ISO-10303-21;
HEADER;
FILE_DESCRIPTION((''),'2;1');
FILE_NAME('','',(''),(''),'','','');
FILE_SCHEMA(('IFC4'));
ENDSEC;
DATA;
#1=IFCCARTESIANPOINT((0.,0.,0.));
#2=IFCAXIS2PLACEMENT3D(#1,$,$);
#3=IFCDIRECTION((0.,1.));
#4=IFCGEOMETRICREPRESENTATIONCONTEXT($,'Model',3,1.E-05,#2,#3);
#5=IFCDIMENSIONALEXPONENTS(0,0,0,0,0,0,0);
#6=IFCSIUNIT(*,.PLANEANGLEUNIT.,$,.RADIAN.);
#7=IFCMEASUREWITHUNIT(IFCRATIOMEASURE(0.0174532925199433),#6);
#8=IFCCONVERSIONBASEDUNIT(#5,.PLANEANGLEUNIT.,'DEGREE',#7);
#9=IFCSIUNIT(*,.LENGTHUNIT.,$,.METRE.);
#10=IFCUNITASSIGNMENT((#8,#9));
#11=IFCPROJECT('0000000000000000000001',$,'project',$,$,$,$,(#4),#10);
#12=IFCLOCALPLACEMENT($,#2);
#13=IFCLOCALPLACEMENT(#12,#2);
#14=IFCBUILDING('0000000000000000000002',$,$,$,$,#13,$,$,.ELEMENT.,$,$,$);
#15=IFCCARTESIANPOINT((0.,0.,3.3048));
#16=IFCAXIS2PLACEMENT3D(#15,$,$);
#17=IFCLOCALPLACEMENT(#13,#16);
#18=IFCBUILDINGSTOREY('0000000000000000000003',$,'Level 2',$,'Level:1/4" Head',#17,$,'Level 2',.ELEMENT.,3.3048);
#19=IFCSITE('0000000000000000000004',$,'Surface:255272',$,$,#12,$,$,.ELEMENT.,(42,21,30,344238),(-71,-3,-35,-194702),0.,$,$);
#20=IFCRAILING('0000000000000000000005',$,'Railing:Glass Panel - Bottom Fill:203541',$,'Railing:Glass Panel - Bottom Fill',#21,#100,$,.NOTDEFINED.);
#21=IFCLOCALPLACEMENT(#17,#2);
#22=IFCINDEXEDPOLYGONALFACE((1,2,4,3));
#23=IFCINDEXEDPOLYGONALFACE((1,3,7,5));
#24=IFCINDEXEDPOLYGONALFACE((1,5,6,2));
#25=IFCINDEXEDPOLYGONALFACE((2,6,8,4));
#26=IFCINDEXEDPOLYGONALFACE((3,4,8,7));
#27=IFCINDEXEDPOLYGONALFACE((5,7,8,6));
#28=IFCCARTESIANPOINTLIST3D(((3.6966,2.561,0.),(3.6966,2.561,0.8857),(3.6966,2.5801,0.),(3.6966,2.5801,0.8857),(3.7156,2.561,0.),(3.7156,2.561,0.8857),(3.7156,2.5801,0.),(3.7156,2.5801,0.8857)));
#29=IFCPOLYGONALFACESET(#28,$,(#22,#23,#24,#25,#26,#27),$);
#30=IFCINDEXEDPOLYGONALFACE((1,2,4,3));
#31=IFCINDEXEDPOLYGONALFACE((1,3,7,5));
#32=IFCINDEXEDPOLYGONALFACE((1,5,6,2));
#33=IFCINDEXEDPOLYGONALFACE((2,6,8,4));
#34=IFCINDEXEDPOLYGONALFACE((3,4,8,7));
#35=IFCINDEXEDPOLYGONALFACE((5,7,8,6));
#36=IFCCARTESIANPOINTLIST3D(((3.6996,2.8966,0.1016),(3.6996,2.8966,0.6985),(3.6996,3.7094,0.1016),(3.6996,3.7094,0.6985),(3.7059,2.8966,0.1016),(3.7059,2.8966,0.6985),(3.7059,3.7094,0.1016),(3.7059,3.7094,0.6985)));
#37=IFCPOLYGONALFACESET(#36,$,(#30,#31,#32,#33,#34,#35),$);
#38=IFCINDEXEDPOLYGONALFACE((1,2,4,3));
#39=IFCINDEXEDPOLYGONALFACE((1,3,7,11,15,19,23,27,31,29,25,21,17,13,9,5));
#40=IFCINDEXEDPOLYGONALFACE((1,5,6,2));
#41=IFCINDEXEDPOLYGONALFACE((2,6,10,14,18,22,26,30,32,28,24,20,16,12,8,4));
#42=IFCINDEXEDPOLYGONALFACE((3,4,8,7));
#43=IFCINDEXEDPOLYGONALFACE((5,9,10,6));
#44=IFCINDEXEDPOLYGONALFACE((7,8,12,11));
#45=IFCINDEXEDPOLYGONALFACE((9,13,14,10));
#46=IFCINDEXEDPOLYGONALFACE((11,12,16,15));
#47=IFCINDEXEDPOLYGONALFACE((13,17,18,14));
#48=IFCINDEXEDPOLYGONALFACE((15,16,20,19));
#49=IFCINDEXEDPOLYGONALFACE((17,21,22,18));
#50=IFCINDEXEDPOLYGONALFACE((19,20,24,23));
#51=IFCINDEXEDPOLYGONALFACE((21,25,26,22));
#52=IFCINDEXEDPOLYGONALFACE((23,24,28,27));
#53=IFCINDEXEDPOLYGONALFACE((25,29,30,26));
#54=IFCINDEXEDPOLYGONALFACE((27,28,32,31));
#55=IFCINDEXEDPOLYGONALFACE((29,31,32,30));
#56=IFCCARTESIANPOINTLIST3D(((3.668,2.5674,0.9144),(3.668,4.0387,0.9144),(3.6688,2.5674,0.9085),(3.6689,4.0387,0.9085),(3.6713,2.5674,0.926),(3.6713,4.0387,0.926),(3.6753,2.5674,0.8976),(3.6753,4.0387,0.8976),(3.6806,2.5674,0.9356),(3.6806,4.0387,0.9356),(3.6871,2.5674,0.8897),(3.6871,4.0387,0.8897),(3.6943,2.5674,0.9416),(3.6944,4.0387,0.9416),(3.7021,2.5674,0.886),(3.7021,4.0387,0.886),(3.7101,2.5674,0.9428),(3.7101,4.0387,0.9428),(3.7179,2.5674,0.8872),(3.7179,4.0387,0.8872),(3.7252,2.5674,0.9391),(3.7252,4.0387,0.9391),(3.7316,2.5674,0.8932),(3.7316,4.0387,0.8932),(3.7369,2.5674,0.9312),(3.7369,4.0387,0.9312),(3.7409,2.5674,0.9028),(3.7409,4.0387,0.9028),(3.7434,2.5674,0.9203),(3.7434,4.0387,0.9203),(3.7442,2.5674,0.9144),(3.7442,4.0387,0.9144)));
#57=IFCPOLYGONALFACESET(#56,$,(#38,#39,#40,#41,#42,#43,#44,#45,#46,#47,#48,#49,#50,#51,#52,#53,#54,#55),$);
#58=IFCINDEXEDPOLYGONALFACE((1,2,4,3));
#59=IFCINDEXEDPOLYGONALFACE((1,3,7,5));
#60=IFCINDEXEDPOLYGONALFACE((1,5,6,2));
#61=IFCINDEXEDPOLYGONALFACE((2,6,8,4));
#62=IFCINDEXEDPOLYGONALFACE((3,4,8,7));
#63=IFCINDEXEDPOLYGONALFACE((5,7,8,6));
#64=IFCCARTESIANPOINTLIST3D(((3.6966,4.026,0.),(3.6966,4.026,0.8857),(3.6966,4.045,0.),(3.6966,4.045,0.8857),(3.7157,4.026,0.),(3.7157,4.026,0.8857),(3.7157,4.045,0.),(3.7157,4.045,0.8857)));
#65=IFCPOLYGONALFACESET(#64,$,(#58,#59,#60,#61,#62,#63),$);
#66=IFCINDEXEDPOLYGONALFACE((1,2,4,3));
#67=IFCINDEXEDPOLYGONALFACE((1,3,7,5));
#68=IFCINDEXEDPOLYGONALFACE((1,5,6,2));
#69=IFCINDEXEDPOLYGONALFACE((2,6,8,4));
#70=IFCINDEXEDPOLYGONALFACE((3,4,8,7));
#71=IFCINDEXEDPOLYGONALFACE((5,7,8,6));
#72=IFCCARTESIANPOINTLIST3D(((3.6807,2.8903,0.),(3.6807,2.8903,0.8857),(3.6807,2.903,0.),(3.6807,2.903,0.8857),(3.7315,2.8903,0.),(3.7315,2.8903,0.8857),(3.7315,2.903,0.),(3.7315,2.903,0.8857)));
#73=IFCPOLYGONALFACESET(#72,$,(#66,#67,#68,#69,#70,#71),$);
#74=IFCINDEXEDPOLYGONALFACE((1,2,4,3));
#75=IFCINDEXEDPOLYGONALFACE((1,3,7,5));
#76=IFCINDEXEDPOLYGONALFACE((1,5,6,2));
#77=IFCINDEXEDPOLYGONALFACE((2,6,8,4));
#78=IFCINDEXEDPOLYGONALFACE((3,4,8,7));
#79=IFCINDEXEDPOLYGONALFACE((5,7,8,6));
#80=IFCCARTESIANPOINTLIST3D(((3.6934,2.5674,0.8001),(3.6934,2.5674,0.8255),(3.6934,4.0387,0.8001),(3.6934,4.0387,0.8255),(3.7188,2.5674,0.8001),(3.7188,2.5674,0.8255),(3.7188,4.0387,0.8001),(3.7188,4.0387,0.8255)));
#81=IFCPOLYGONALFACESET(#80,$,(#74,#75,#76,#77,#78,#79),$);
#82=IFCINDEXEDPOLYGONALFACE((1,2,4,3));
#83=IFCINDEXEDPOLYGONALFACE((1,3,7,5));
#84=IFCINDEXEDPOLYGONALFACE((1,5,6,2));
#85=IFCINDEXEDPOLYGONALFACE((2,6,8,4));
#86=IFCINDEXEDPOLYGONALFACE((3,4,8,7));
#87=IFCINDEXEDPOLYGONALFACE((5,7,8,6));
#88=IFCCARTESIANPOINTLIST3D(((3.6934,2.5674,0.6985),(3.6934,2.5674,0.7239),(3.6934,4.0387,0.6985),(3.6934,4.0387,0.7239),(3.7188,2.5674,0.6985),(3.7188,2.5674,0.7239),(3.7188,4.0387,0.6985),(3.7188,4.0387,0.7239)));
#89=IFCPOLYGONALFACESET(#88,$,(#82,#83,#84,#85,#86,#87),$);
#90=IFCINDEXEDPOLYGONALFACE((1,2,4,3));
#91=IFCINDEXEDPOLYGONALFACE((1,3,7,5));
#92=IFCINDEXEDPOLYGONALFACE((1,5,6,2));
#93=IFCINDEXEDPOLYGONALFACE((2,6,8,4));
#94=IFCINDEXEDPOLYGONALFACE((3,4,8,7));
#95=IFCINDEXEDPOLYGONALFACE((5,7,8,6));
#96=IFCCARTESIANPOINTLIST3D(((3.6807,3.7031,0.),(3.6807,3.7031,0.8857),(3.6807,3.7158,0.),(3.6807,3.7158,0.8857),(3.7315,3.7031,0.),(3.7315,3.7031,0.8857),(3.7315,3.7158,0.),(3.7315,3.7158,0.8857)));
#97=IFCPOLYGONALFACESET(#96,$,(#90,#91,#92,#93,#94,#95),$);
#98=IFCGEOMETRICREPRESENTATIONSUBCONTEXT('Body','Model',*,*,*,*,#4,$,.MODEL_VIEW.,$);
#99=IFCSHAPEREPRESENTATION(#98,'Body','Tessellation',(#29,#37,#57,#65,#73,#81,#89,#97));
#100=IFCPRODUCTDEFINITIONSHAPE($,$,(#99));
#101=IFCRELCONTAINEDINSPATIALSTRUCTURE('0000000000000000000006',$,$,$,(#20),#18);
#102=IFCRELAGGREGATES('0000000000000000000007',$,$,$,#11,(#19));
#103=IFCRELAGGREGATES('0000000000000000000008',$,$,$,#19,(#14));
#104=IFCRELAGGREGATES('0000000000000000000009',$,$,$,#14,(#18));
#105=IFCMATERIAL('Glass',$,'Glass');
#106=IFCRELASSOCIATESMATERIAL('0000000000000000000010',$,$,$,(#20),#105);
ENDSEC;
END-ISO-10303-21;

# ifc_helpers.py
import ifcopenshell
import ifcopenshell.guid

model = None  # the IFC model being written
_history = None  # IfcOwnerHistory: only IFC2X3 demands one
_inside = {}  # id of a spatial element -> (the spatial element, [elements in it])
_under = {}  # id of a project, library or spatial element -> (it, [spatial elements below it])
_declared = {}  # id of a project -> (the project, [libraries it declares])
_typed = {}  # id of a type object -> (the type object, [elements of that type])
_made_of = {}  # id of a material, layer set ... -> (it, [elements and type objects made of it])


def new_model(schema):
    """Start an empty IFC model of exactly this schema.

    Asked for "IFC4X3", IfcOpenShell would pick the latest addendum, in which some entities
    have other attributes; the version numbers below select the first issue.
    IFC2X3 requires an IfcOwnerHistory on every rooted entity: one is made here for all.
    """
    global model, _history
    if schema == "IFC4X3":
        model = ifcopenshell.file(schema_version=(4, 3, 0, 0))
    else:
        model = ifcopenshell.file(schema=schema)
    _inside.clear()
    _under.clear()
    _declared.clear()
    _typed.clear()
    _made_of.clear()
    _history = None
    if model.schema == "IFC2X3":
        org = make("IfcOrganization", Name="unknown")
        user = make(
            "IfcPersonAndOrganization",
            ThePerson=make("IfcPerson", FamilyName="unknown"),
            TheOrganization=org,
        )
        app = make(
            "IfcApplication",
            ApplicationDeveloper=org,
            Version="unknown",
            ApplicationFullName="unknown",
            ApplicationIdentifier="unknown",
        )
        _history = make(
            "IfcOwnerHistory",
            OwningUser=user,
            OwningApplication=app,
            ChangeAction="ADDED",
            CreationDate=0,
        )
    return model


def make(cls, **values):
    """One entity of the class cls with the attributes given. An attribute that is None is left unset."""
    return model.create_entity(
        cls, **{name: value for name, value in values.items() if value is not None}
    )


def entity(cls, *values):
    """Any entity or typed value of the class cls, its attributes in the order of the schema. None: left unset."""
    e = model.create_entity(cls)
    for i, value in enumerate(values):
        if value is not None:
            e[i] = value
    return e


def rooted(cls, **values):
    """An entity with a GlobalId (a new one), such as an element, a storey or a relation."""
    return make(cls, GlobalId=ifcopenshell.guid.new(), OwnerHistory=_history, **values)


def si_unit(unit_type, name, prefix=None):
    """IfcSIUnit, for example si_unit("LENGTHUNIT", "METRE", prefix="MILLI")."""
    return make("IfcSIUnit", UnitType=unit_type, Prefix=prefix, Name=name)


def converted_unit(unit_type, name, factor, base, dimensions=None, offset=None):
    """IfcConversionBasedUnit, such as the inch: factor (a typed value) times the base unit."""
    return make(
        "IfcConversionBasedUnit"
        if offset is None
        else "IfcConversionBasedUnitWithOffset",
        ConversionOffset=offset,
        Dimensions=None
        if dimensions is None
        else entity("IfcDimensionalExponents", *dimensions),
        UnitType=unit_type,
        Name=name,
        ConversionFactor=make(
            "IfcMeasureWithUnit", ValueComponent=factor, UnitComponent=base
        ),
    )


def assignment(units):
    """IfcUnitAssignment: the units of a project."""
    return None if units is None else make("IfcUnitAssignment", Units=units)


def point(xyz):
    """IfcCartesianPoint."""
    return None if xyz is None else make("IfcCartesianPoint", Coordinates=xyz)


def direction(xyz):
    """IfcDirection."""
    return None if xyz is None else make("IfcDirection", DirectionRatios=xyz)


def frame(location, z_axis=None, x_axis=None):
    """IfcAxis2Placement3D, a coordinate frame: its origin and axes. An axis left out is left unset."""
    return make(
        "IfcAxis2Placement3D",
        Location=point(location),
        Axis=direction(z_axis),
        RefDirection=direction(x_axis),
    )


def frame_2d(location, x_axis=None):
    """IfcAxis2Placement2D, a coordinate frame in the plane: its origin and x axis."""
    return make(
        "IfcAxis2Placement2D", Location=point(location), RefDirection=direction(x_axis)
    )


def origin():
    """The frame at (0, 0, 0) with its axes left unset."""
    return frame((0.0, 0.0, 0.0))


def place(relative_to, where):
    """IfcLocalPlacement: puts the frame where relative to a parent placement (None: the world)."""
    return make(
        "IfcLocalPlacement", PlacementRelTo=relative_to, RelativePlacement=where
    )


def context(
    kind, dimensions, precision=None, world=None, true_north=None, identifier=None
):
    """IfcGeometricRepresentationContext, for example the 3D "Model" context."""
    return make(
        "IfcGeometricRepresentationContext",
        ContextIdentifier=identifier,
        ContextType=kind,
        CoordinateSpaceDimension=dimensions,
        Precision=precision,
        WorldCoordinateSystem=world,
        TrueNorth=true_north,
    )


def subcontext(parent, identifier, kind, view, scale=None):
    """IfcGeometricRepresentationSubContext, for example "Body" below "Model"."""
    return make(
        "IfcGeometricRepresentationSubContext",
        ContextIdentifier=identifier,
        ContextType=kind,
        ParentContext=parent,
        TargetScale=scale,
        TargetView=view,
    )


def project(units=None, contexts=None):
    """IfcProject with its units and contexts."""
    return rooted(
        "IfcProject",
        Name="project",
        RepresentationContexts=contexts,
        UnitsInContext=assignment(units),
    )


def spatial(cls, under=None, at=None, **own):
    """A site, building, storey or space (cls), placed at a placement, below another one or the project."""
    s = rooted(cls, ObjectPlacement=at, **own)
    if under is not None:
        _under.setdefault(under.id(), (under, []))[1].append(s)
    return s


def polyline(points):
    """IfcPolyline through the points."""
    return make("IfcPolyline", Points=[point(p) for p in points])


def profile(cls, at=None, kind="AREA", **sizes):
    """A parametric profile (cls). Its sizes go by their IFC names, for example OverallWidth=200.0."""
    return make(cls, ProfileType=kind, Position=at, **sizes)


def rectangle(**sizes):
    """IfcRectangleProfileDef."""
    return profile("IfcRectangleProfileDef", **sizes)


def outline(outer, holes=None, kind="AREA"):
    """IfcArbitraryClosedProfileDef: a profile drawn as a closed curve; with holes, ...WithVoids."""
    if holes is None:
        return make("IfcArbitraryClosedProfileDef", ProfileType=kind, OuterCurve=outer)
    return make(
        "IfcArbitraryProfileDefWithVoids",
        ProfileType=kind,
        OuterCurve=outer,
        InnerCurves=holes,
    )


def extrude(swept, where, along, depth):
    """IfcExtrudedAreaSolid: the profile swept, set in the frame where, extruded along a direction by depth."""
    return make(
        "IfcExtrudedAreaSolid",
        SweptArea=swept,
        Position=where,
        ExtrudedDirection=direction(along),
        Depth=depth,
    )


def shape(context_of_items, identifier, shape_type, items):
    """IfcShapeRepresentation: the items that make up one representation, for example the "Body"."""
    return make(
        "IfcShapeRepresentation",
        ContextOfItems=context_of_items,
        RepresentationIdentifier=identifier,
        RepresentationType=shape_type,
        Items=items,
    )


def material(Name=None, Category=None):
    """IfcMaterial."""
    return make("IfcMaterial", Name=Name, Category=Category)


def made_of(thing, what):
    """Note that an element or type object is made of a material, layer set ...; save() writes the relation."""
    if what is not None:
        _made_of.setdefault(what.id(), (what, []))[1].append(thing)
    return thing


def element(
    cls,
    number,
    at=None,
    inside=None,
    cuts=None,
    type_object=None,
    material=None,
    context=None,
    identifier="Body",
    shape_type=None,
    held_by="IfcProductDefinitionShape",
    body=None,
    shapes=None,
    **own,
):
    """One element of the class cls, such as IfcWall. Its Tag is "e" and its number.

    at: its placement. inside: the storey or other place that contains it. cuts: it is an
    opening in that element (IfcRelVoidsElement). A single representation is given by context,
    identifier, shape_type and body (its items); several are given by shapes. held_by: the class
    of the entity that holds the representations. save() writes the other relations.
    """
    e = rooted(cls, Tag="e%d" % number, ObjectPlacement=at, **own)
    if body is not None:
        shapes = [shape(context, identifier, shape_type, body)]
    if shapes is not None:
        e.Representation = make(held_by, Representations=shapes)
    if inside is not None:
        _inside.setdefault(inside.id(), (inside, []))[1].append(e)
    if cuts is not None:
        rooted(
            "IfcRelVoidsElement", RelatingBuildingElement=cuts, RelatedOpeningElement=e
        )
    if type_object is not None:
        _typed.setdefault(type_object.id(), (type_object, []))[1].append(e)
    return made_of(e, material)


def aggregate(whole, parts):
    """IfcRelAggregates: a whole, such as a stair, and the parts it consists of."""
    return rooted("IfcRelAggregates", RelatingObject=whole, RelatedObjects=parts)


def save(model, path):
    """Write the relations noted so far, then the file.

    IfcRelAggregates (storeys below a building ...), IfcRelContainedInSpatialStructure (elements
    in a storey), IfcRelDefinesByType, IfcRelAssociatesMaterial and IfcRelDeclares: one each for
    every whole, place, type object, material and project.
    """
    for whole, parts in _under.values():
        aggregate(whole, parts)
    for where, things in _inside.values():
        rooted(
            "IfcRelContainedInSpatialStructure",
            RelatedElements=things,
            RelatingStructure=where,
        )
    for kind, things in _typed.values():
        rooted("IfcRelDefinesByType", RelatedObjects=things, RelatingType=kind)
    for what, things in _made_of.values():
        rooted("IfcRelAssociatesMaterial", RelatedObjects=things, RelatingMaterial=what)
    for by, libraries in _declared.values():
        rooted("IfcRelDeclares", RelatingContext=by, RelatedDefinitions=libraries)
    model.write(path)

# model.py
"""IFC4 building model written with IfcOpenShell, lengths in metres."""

from ifc_helpers import new_model, entity, si_unit, converted_unit, direction, frame, frame_2d, origin, place, context, subcontext, project, spatial, polyline, rectangle, outline, extrude, material, element, save


model = new_model("IFC4")

# Units and contexts
model_context = context("Model", 3, precision=1e-05, world=origin(), true_north=direction((0.0, 1.0)))
body_context = subcontext(model_context, "Body", "Model", "MODEL_VIEW")
ifc_project = project(units=[converted_unit("PLANEANGLEUNIT", "DEGREE", entity("IfcRatioMeasure", 0.0174532925199433), si_unit("PLANEANGLEUNIT", "RADIAN"), dimensions=[0, 0, 0, 0, 0, 0, 0]), si_unit("LENGTHUNIT", "METRE")], contexts=[model_context])

# Site, building, storey
site_placement = place(None, origin())
site = spatial("IfcSite", under=ifc_project, at=site_placement, Name="Surface:255272", CompositionType="ELEMENT", RefLatitude=(42, 21, 30, 344238), RefLongitude=(-71, -3, -35, -194702), RefElevation=0.0)
building_placement = place(site_placement, origin())
building = spatial("IfcBuilding", under=site, at=building_placement, CompositionType="ELEMENT")
storey_placement = place(building_placement, frame((0.0, 0.0, 3.3048)))
storey = spatial("IfcBuildingStorey", under=building, at=storey_placement, Name="Level 2", ObjectType="Level:1/4\" Head", LongName="Level 2", CompositionType="ELEMENT", Elevation=3.3048)

# Shared definitions
ifc_material_1 = material(Name="Glass", Category="Glass")

# Railing
railing_placement = place(storey_placement, frame((3.6664, 2.561, 0.0)))
element("IfcRailing", 1, at=railing_placement, inside=storey, material=ifc_material_1, Name="Railing:Glass Panel - Bottom Fill:203541", ObjectType="Railing:Glass Panel - Bottom Fill", PredefinedType="NOTDEFINED", context=body_context, shape_type="SweptSolid", body=[
    extrude(rectangle(XDim=0.0191, YDim=0.0191, at=frame_2d((0.0, 0.0), x_axis=(1.0, 0.0))), frame((0.0397, 0.0095, 0.0), z_axis=(0.0, 0.0, 1.0), x_axis=(0.000007, 1.0, 0.0)), (0.0, 0.0, 1.0), 0.8857),
    extrude(rectangle(XDim=0.0064, YDim=0.8128, at=frame_2d((0.0, 0.0), x_axis=(1.0, 0.0))), frame((0.0363, 0.742, 0.1016)), (0.0, 0.0, 1.0), 0.5969),
    extrude(outline(polyline([(-0.0104, -0.0367), (0.0017, -0.0367), (0.0135, -0.0303), (0.0229, -0.0187), (0.0284, -0.0039), (0.029, 0.0116), (0.0246, 0.0251), (0.0159, 0.0342), (0.0104, 0.0367), (-0.0017, 0.0367), (-0.0135, 0.0303), (-0.0229, 0.0187), (-0.0284, 0.0039), (-0.029, -0.0116), (-0.0246, -0.0251), (-0.0159, -0.0342), (-0.0104, -0.0367)])), frame((0.0397, 0.0064, 0.9144), z_axis=(0.000007, 1.0, 0.0), x_axis=(-0.27267, 0.000002, -0.962108)), (0.0, 0.0, 1.0), 1.4713),
    extrude(rectangle(XDim=0.0191, YDim=0.0191, at=frame_2d((0.0, 0.0), x_axis=(1.0, 0.0))), frame((0.0397, 1.4745, 0.0), z_axis=(0.0, 0.0, 1.0), x_axis=(0.000007, 1.0, 0.0)), (0.0, 0.0, 1.0), 0.8857),
    extrude(rectangle(XDim=0.0127, YDim=0.0508, at=frame_2d((0.0, 0.0), x_axis=(1.0, 0.0))), frame((0.0397, 0.3356, 0.0), z_axis=(0.0, 0.0, 1.0), x_axis=(0.000007, 1.0, 0.0)), (0.0, 0.0, 1.0), 0.8857),
    extrude(rectangle(XDim=1.4713, YDim=0.0254, at=frame_2d((0.0, 0.0), x_axis=(1.0, 0.0))), frame((0.0397, 0.742, 0.8001), z_axis=(0.0, 0.0, 1.0), x_axis=(0.000007, 1.0, 0.0)), (0.0, 0.0, 1.0), 0.0254),
    extrude(rectangle(XDim=1.4713, YDim=0.0254, at=frame_2d((0.0, 0.0), x_axis=(1.0, 0.0))), frame((0.0397, 0.742, 0.6985), z_axis=(0.0, 0.0, 1.0), x_axis=(0.000007, 1.0, 0.0)), (0.0, 0.0, 1.0), 0.0254),
    extrude(rectangle(XDim=0.0127, YDim=0.0508, at=frame_2d((0.0, 0.0), x_axis=(1.0, 0.0))), frame((0.0397, 1.1484, 0.0), z_axis=(0.0, 0.0, 1.0), x_axis=(0.000007, 1.0, 0.0)), (0.0, 0.0, 1.0), 0.8857),
])

save(model, "model.ifc")
